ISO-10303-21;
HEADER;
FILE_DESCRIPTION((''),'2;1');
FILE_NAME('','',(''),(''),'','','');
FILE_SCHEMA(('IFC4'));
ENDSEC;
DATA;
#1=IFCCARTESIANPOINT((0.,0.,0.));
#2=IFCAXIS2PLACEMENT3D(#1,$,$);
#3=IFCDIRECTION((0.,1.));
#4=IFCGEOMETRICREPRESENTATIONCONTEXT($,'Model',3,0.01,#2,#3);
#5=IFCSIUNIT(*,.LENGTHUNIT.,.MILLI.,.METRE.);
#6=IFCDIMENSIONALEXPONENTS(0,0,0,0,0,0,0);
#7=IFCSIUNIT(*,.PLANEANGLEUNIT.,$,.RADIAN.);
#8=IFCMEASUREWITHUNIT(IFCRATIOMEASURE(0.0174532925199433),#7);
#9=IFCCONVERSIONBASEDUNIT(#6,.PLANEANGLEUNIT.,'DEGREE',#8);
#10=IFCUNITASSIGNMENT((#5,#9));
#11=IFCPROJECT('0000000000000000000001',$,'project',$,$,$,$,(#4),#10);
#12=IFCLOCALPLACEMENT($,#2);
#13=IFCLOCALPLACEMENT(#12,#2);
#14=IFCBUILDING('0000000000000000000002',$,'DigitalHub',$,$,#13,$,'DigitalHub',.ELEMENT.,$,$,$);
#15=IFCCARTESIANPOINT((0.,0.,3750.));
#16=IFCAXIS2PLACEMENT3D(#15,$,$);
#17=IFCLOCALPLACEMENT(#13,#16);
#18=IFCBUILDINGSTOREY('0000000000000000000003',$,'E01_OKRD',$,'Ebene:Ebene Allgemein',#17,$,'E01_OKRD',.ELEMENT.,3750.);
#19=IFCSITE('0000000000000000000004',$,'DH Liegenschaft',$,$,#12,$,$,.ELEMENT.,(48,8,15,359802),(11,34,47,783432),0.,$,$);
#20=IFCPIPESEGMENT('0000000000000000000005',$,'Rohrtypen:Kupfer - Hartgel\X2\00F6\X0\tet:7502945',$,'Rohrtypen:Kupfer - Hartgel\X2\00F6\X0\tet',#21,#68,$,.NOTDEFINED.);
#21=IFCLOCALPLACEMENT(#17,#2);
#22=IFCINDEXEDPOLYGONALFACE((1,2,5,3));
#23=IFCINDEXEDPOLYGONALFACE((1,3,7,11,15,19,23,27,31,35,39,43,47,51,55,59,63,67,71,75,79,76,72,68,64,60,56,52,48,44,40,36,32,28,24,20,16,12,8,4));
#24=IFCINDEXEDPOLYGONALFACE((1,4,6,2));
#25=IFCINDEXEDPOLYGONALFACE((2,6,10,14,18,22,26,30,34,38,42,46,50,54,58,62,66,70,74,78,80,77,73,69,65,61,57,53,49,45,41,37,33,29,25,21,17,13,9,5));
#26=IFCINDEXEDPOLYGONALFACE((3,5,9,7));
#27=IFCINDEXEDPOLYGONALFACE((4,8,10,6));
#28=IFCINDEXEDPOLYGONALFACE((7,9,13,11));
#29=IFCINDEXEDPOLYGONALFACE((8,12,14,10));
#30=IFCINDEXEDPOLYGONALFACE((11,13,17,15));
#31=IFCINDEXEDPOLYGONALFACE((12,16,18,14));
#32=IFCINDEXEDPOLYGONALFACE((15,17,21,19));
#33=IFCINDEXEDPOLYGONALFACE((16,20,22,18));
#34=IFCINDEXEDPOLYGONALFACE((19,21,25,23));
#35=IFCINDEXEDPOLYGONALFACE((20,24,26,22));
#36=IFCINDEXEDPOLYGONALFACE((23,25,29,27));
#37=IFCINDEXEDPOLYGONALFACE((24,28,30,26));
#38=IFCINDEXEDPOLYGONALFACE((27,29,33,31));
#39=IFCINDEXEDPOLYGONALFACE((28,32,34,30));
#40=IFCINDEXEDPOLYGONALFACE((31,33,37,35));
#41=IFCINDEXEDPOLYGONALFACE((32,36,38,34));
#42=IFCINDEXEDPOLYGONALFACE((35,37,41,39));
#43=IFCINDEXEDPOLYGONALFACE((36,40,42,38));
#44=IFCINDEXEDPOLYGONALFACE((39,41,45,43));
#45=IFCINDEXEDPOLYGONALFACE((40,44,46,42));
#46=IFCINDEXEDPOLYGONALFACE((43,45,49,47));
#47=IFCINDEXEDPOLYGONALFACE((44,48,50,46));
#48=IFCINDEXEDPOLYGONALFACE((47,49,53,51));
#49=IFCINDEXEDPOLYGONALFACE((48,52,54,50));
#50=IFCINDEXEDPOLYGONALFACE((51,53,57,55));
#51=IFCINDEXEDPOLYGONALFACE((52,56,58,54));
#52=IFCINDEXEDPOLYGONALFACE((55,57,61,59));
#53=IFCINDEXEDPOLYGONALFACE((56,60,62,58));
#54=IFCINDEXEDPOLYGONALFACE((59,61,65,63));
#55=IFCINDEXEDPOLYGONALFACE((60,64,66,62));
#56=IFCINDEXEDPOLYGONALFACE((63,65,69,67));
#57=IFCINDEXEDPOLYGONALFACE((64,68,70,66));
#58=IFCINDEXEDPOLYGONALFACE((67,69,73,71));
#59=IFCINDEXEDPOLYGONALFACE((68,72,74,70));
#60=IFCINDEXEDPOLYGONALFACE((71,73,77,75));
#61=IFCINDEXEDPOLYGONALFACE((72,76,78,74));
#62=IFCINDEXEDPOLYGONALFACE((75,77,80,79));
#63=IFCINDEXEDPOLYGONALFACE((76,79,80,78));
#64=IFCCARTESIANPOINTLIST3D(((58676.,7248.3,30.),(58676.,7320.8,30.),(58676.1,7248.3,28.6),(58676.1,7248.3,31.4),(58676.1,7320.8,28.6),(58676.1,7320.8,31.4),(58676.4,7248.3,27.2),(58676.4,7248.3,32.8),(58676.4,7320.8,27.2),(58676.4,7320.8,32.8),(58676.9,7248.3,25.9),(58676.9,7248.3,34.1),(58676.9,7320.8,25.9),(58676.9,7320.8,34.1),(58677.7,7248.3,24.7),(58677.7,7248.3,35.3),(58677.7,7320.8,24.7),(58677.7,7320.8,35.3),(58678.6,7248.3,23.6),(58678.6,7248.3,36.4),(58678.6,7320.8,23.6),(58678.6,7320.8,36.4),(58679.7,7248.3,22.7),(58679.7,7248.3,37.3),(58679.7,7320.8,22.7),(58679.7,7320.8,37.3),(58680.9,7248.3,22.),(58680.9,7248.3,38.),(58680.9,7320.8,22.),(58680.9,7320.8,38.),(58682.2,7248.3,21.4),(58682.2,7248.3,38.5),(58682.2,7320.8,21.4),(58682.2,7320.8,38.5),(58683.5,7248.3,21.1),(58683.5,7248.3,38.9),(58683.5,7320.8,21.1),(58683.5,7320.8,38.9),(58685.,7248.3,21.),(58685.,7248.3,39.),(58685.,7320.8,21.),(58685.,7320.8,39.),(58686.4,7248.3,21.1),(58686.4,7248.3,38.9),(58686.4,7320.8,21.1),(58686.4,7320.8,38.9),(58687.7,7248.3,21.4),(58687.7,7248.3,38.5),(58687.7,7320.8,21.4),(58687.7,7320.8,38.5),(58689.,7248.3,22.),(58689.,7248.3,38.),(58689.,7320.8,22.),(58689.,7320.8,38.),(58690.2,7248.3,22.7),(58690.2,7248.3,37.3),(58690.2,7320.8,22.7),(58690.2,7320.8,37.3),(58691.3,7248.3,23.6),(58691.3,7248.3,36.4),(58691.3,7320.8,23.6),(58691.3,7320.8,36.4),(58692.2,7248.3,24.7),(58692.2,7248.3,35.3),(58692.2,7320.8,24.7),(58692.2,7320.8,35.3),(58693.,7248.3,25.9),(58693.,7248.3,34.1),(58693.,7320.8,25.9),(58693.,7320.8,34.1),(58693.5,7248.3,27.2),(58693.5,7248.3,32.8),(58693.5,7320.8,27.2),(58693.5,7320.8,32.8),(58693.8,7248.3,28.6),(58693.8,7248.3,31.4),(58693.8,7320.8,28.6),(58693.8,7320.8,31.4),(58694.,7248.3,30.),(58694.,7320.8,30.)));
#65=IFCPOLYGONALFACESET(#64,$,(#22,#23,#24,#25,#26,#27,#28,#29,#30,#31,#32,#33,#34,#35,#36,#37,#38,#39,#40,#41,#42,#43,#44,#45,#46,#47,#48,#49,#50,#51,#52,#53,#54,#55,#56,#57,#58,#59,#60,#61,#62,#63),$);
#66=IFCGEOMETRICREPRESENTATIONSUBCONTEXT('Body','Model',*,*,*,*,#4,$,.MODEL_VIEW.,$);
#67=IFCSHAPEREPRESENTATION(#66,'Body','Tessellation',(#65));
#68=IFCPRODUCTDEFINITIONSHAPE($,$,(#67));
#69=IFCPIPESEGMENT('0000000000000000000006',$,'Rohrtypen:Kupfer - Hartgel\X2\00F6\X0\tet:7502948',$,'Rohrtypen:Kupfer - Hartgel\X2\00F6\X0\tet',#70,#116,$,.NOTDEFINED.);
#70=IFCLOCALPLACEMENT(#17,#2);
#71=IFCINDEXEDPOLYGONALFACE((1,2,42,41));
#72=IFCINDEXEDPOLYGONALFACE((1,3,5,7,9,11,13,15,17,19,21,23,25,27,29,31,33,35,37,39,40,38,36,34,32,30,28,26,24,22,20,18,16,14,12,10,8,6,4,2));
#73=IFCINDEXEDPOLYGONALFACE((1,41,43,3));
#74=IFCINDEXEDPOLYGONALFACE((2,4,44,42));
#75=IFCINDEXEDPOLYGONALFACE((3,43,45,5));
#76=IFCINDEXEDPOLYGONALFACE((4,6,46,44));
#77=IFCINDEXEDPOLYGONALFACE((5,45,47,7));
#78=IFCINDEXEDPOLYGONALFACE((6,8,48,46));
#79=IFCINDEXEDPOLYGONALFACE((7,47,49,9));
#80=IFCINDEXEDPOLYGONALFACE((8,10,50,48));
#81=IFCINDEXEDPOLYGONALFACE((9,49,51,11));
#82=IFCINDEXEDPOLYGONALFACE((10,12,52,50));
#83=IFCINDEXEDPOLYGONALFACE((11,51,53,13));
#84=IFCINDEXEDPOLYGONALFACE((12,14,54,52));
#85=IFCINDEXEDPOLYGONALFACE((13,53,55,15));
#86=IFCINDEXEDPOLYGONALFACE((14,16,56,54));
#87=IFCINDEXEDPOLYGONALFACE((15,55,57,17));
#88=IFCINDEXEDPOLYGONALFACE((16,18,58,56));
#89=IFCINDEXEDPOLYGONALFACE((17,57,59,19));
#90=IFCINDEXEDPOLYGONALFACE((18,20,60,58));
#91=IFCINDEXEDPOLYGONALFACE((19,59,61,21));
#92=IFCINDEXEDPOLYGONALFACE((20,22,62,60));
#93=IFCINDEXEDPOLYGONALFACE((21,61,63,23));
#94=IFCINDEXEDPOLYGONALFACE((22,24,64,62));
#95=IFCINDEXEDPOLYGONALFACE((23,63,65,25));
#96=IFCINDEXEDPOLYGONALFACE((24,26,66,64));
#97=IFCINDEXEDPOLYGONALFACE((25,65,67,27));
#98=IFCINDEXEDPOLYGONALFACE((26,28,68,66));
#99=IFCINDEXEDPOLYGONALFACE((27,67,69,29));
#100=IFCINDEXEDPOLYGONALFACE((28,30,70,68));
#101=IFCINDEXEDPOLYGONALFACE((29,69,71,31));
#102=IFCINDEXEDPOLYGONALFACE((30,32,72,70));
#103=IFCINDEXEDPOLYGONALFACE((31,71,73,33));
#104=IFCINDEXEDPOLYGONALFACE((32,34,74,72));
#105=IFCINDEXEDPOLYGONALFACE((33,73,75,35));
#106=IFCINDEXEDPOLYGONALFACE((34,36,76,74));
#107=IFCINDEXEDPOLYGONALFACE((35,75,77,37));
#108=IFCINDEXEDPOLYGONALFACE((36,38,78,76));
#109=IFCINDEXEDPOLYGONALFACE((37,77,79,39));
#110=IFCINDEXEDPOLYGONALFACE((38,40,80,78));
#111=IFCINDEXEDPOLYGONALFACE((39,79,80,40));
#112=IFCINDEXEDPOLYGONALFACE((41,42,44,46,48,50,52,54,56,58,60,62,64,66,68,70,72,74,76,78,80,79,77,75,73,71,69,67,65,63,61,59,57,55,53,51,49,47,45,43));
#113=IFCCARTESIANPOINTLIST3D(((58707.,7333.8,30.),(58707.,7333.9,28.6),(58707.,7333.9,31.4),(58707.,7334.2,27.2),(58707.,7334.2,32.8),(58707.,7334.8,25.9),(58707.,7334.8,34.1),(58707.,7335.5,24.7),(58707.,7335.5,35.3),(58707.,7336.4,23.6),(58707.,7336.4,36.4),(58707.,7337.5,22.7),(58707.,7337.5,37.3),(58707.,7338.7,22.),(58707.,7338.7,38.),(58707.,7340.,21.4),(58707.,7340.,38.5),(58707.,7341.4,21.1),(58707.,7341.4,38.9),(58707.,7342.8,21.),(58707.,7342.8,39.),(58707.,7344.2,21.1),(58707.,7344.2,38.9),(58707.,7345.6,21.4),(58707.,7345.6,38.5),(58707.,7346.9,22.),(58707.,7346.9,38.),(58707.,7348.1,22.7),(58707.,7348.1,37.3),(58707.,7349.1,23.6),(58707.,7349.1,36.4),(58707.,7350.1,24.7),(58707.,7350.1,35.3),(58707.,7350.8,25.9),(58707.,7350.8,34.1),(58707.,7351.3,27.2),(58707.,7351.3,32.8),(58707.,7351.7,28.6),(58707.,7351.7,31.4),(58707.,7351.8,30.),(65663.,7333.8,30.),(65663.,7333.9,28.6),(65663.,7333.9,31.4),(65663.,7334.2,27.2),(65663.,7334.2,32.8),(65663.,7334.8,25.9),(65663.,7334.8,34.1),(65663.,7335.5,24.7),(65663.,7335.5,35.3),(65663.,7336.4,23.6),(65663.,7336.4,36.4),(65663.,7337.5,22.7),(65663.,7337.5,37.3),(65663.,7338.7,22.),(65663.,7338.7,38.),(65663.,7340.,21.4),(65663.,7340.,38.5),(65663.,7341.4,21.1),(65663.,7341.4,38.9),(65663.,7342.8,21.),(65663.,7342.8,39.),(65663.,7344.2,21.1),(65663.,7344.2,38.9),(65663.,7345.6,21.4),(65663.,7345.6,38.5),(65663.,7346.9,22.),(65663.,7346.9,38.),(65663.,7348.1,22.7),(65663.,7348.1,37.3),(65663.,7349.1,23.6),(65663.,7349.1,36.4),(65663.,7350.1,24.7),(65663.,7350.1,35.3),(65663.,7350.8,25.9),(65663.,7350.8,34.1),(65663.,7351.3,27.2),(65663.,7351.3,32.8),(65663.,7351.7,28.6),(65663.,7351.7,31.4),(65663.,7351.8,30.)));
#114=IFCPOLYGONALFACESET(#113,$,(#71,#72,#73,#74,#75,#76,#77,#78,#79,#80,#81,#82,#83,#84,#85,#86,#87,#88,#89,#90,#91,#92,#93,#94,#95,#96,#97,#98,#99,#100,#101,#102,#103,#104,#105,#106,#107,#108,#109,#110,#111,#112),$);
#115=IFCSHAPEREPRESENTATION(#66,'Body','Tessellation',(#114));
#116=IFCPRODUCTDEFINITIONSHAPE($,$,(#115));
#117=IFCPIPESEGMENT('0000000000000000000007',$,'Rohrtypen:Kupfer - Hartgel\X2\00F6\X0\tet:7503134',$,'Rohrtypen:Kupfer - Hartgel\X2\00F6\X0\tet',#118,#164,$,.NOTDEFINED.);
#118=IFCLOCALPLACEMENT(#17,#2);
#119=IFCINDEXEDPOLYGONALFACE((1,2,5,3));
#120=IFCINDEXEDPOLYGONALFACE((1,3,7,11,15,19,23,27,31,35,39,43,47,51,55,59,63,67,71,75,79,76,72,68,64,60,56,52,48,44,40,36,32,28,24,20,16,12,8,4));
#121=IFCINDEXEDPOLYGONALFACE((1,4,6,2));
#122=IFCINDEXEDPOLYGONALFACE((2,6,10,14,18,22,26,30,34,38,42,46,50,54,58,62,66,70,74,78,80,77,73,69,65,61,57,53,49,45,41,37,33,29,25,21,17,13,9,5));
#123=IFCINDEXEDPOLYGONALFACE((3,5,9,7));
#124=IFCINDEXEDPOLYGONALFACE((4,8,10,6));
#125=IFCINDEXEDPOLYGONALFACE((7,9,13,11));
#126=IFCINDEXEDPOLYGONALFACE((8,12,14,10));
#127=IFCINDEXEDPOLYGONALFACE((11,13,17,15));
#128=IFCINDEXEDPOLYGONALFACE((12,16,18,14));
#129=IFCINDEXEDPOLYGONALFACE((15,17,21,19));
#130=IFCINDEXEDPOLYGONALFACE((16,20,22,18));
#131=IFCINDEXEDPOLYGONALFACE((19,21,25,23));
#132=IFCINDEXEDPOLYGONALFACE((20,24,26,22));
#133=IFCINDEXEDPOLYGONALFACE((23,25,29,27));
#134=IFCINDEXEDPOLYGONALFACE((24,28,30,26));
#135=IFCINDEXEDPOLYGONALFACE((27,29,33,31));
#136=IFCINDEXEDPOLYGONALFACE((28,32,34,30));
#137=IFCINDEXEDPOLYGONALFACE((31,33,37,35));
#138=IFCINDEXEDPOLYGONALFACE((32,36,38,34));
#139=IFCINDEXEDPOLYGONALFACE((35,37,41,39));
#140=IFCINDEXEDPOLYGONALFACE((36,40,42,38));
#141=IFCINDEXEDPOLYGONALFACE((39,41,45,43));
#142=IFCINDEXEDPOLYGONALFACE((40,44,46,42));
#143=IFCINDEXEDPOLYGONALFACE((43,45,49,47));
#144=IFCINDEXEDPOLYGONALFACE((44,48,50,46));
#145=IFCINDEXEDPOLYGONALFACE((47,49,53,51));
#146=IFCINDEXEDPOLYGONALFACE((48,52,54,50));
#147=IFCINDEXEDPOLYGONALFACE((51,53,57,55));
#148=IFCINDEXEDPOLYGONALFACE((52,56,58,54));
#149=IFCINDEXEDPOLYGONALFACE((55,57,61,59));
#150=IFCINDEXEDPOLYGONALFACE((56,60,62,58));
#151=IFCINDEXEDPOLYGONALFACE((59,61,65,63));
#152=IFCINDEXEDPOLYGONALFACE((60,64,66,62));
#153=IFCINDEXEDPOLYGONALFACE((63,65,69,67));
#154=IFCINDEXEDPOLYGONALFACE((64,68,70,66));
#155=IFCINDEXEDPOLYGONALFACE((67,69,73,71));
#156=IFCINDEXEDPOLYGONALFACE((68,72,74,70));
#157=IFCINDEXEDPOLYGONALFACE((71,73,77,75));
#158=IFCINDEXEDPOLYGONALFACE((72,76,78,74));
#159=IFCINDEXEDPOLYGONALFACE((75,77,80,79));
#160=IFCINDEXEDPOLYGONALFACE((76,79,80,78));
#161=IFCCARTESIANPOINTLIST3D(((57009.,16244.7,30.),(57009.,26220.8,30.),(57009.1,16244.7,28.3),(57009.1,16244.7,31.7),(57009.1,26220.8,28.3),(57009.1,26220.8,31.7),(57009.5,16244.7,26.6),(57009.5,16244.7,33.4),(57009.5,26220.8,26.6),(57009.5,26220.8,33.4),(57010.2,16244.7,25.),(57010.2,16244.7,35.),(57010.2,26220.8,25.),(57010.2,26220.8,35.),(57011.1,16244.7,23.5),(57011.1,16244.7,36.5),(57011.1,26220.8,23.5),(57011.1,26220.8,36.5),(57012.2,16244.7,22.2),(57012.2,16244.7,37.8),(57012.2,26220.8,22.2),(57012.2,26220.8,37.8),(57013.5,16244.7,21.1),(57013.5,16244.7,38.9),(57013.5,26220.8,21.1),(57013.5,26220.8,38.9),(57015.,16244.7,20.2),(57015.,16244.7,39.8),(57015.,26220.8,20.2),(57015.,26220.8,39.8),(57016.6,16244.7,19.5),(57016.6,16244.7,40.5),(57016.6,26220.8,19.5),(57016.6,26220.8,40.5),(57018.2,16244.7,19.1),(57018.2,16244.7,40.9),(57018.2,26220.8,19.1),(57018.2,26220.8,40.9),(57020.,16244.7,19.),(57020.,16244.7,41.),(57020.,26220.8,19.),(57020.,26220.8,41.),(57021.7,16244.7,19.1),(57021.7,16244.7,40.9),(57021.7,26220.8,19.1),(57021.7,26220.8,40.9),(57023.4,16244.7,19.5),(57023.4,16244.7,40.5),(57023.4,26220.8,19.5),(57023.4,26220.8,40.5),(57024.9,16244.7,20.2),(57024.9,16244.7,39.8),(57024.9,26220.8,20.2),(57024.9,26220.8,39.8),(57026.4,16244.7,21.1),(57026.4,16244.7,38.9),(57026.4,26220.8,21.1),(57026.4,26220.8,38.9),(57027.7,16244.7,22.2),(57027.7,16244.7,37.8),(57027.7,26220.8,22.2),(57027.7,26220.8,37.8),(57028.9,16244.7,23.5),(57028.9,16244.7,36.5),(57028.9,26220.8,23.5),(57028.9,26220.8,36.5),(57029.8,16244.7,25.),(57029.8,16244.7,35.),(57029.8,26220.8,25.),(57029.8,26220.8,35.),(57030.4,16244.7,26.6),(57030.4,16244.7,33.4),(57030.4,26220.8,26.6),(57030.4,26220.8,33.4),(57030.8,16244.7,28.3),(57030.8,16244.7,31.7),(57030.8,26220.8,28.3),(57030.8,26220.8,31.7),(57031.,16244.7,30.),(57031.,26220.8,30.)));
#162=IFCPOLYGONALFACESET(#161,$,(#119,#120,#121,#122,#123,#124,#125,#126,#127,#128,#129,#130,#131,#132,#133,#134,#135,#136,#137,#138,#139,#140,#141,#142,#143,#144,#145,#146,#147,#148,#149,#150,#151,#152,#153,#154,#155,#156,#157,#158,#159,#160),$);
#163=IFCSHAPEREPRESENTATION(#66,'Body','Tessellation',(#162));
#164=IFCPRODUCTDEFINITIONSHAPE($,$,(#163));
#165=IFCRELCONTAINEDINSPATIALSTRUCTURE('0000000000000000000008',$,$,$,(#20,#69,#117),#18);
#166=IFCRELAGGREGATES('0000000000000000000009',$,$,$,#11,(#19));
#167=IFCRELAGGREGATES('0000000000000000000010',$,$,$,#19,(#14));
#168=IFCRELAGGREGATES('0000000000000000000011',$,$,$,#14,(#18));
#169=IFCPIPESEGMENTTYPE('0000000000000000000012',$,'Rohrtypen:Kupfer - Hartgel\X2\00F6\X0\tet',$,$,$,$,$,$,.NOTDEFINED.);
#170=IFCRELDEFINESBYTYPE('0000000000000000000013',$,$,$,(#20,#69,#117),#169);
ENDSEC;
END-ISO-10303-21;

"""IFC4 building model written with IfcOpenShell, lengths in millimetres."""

from ifc_helpers import new_model, entity, si_unit, converted_unit, direction, frame, origin, place, context, subcontext, project, spatial, indexed_curve, outline, extrude, type_object, element, save


model = new_model("IFC4")

# Units and contexts
model_context = context("Model", 3, precision=0.01, world=origin(), true_north=direction((0.0, 1.0)))
body_context = subcontext(model_context, "Body", "Model", "MODEL_VIEW")
ifc_project = project(units=[si_unit("LENGTHUNIT", "METRE", prefix="MILLI"), converted_unit("PLANEANGLEUNIT", "DEGREE", entity("IfcRatioMeasure", 0.0174532925199433), si_unit("PLANEANGLEUNIT", "RADIAN"), dimensions=[0, 0, 0, 0, 0, 0, 0])], contexts=[model_context])

# Site, building, storey
site_placement = place(None, origin())
site = spatial("IfcSite", under=ifc_project, at=site_placement, Name="DH Liegenschaft", CompositionType="ELEMENT", RefLatitude=(48, 8, 15, 359802), RefLongitude=(11, 34, 47, 783432), RefElevation=0.0)
building_placement = place(site_placement, origin())
building = spatial("IfcBuilding", under=site, at=building_placement, Name="DigitalHub", LongName="DigitalHub", CompositionType="ELEMENT")
storey_placement = place(building_placement, frame((0.0, 0.0, 3750.0)))
storey = spatial("IfcBuildingStorey", under=building, at=storey_placement, Name="E01_OKRD", ObjectType="Ebene:Ebene Allgemein", LongName="E01_OKRD", CompositionType="ELEMENT", Elevation=3750.0)

# Pipe segments
pipe_segment_type = type_object("IfcPipeSegmentType", Name="Rohrtypen:Kupfer - Hartgelötet", PredefinedType="NOTDEFINED")
pipe_segment_1_placement = place(storey_placement, frame((58674.4, 7248.3, 19.4)))
element("IfcPipeSegment", 1, at=pipe_segment_1_placement, inside=storey, type_object=pipe_segment_type, Name="Rohrtypen:Kupfer - Hartgelötet:7502945", ObjectType="Rohrtypen:Kupfer - Hartgelötet", PredefinedType="NOTDEFINED", context=body_context, shape_type="SweptSolid", body=[
    extrude(outline(indexed_curve([(9.0, 0.0), (8.9, 1.4), (8.6, 2.8), (8.0, 4.1), (7.3, 5.3), (6.4, 6.4), (5.3, 7.3), (4.1, 8.0), (2.8, 8.6), (1.4, 8.9), (0.0, 9.0), (-1.4, 8.9), (-2.8, 8.6), (-4.1, 8.0), (-5.3, 7.3), (-6.4, 6.4), (-7.3, 5.3), (-8.0, 4.1), (-8.6, 2.8), (-8.9, 1.4), (-9.0, 0.0), (-8.9, -1.4), (-8.6, -2.8), (-8.0, -4.1), (-7.3, -5.3), (-6.4, -6.4), (-5.3, -7.3), (-4.1, -8.0), (-2.8, -8.6), (-1.4, -8.9), (0.0, -9.0), (1.4, -8.9), (2.8, -8.6), (4.1, -8.0), (5.3, -7.3), (6.4, -6.4), (7.3, -5.3), (8.0, -4.1), (8.6, -2.8), (8.9, -1.4), (9.0, 0.0)], self_intersect=False)), frame((10.6, 0.0, 10.6), z_axis=(0.0, 1.0, 0.0), x_axis=(-1.0, 0.0, 0.0)), (0.0, 0.0, 1.0), 72.4),
])
pipe_segment_2_placement = place(storey_placement, frame((58707.0, 7332.2, 19.4)))
element("IfcPipeSegment", 2, at=pipe_segment_2_placement, inside=storey, type_object=pipe_segment_type, Name="Rohrtypen:Kupfer - Hartgelötet:7502948", ObjectType="Rohrtypen:Kupfer - Hartgelötet", PredefinedType="NOTDEFINED", context=body_context, shape_type="SweptSolid", body=[
    extrude(outline(indexed_curve([(9.0, 0.0), (8.9, 1.4), (8.6, 2.8), (8.0, 4.1), (7.3, 5.3), (6.4, 6.4), (5.3, 7.3), (4.1, 8.0), (2.8, 8.6), (1.4, 8.9), (0.0, 9.0), (-1.4, 8.9), (-2.8, 8.6), (-4.1, 8.0), (-5.3, 7.3), (-6.4, 6.4), (-7.3, 5.3), (-8.0, 4.1), (-8.6, 2.8), (-8.9, 1.4), (-9.0, 0.0), (-8.9, -1.4), (-8.6, -2.8), (-8.0, -4.1), (-7.3, -5.3), (-6.4, -6.4), (-5.3, -7.3), (-4.1, -8.0), (-2.8, -8.6), (-1.4, -8.9), (0.0, -9.0), (1.4, -8.9), (2.8, -8.6), (4.1, -8.0), (5.3, -7.3), (6.4, -6.4), (7.3, -5.3), (8.0, -4.1), (8.6, -2.8), (8.9, -1.4), (9.0, 0.0)], self_intersect=False)), frame((0.0, 10.6, 10.6), z_axis=(1.0, 0.0, 0.0), x_axis=(0.0, 1.0, 0.0)), (0.0, 0.0, 1.0), 6956.0),
])
pipe_segment_3_placement = place(storey_placement, frame((57007.4, 16244.7, 17.4)))
element("IfcPipeSegment", 3, at=pipe_segment_3_placement, inside=storey, type_object=pipe_segment_type, Name="Rohrtypen:Kupfer - Hartgelötet:7503134", ObjectType="Rohrtypen:Kupfer - Hartgelötet", PredefinedType="NOTDEFINED", context=body_context, shape_type="SweptSolid", body=[
    extrude(outline(indexed_curve([(11.0, 0.0), (10.9, 1.7), (10.5, 3.4), (9.8, 5.0), (8.9, 6.5), (7.8, 7.8), (6.5, 8.9), (5.0, 9.8), (3.4, 10.5), (1.7, 10.9), (0.0, 11.0), (-1.7, 10.9), (-3.4, 10.5), (-5.0, 9.8), (-6.5, 8.9), (-7.8, 7.8), (-8.9, 6.5), (-9.8, 5.0), (-10.5, 3.4), (-10.9, 1.7), (-11.0, 0.0), (-10.9, -1.7), (-10.5, -3.4), (-9.8, -5.0), (-8.9, -6.5), (-7.8, -7.8), (-6.5, -8.9), (-5.0, -9.8), (-3.4, -10.5), (-1.7, -10.9), (0.0, -11.0), (1.7, -10.9), (3.4, -10.5), (5.0, -9.8), (6.5, -8.9), (7.8, -7.8), (8.9, -6.5), (9.8, -5.0), (10.5, -3.4), (10.9, -1.7), (11.0, 0.0)], self_intersect=False)), frame((12.6, 0.0, 12.6), z_axis=(0.0, 1.0, 0.0), x_axis=(-1.0, 0.0, 0.0)), (0.0, 0.0, 1.0), 9976.1),
])

save(model, "model.ifc")
